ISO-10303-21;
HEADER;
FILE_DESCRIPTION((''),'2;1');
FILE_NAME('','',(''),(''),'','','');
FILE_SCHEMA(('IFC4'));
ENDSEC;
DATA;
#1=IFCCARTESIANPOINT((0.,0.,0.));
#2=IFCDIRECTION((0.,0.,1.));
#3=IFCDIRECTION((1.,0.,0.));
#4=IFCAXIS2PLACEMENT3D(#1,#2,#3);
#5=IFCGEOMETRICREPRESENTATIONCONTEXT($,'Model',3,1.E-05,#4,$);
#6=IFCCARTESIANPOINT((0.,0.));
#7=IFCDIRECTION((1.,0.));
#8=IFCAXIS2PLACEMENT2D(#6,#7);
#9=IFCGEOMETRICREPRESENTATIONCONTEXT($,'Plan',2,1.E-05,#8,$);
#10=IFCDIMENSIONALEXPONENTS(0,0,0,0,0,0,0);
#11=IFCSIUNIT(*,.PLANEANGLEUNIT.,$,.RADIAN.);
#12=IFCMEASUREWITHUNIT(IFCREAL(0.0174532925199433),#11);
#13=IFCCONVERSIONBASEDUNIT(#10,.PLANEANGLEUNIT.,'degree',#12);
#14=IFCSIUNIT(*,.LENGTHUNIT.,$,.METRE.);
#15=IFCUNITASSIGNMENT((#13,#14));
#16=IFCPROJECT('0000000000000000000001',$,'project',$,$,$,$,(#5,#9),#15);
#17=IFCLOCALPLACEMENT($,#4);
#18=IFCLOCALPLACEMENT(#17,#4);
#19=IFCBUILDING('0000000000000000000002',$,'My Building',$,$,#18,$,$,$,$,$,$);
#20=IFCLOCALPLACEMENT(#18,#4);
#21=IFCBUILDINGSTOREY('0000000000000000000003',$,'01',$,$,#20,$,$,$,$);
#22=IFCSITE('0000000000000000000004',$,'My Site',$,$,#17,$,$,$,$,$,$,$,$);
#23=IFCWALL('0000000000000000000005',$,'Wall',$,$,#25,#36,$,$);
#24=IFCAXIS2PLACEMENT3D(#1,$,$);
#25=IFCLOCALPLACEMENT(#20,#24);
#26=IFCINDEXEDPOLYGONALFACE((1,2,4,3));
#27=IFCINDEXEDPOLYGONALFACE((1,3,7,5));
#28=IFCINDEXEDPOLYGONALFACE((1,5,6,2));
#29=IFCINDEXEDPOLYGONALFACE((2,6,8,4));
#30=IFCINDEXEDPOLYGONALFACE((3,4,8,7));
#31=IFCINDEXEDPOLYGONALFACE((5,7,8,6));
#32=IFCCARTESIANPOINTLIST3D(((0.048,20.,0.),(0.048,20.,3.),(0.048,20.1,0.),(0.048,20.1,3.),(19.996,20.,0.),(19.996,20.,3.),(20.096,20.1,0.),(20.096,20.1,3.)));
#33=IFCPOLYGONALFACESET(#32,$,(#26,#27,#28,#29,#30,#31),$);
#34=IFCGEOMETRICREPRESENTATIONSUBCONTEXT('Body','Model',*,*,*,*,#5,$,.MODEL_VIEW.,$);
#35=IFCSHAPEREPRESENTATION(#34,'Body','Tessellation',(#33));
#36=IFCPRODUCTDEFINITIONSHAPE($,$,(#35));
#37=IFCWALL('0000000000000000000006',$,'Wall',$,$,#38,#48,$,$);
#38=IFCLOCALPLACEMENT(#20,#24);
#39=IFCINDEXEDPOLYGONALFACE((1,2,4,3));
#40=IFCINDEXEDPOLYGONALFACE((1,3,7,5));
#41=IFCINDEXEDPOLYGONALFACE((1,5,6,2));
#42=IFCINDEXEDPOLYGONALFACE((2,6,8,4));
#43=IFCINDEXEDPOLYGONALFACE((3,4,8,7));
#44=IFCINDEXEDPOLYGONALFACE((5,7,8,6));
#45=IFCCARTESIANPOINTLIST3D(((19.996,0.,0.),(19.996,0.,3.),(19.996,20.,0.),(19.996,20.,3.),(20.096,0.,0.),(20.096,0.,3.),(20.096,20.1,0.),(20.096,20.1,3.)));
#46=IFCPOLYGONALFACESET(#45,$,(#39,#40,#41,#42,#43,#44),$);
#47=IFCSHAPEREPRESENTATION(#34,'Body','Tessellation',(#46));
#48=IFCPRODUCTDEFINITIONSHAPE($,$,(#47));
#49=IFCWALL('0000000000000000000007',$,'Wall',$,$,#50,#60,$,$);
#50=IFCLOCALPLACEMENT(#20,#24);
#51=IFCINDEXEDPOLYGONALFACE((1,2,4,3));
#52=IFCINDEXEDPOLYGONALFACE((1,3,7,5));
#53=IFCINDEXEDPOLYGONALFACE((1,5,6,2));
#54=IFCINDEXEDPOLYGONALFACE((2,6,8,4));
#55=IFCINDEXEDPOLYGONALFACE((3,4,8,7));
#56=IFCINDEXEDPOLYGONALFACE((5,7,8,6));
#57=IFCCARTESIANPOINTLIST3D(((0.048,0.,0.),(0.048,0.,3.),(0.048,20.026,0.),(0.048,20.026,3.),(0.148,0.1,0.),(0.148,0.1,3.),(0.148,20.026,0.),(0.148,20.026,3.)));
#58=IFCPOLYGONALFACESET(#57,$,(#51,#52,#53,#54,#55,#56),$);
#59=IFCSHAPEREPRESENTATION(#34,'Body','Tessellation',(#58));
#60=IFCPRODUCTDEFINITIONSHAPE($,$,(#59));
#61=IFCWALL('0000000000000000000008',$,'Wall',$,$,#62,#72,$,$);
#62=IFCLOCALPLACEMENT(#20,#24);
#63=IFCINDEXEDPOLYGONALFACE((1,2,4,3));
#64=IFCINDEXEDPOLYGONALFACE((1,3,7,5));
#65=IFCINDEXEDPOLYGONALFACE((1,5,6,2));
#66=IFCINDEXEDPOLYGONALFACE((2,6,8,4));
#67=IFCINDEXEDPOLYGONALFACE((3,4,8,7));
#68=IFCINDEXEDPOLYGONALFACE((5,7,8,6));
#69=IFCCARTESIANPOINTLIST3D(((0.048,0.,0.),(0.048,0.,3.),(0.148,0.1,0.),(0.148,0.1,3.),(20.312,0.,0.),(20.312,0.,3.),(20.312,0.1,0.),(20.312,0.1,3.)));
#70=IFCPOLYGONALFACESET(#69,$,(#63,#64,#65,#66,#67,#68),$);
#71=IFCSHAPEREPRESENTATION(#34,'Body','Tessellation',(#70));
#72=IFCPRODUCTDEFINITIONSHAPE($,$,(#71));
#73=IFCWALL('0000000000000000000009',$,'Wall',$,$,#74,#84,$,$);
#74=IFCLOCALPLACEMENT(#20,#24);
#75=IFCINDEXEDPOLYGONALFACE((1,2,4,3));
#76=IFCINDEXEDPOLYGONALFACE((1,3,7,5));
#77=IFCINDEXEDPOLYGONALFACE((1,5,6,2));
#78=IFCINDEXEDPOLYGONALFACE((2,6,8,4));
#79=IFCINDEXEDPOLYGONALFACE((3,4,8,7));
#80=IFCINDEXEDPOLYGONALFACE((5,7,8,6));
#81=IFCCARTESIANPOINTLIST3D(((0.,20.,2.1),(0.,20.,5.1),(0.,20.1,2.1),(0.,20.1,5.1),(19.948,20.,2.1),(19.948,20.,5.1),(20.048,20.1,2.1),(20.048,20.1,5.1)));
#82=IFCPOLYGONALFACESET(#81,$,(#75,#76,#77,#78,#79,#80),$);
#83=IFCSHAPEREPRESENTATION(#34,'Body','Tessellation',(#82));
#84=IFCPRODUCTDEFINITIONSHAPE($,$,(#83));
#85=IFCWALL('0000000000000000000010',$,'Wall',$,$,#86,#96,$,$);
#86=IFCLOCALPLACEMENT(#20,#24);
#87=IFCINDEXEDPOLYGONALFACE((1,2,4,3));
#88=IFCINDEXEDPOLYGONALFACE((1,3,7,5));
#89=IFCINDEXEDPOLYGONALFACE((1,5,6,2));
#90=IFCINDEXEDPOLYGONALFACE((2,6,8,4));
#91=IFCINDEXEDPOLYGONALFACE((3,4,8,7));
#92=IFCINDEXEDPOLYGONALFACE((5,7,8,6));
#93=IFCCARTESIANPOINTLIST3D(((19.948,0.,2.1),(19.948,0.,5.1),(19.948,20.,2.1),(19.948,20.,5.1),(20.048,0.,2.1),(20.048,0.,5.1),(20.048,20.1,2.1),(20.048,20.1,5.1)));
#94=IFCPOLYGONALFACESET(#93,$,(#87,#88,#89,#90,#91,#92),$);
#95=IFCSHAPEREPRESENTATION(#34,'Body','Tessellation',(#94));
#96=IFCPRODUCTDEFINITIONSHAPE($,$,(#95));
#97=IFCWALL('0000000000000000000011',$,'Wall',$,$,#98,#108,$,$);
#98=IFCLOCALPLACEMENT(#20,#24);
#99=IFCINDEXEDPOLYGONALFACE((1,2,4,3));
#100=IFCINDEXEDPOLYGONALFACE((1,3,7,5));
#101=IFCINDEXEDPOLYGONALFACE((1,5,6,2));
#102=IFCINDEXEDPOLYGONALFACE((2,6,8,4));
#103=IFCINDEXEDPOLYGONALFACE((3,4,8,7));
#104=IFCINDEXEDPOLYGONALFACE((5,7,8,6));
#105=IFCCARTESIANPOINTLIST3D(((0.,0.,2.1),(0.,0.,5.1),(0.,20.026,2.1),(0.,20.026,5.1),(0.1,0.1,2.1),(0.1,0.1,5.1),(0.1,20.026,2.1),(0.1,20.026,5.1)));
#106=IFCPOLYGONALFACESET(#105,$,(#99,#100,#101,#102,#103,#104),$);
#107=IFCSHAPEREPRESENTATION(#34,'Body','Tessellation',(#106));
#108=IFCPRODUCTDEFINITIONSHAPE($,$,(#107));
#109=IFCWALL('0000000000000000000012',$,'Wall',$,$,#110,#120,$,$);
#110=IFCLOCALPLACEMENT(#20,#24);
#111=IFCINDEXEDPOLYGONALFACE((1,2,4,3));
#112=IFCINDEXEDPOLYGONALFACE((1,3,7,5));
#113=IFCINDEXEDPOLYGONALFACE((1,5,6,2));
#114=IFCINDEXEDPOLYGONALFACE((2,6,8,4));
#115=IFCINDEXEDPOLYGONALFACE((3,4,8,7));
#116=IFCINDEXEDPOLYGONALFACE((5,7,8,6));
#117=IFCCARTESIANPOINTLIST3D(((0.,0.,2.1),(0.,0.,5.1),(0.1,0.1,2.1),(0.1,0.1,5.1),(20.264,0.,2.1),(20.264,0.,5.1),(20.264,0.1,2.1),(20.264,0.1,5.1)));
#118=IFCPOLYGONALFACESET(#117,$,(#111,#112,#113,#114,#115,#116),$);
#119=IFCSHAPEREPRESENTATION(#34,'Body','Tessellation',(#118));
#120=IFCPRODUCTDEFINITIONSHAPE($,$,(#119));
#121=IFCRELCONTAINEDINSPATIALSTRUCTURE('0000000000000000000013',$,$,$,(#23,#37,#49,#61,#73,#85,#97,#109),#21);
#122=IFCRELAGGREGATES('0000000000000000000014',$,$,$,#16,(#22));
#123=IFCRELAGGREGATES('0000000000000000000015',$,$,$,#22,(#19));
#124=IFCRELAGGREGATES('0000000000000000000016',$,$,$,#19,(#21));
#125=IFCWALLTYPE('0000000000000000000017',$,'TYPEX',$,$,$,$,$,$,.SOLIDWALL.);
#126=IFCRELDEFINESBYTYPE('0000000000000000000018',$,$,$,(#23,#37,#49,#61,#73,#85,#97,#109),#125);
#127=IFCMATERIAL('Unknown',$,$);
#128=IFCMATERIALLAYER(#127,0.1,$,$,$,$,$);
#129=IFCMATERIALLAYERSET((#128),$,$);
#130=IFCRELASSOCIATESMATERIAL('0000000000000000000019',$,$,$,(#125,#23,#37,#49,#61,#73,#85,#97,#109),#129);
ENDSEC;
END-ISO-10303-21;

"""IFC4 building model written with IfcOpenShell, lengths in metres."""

from ifc_helpers import new_model, entity, si_unit, converted_unit, frame, origin_with_axes, origin_2d_with_axis, place, context, subcontext, project, spatial, indexed_curve, outline, extrude, clip, halfspace, material, layer, layer_set, layer_usage, type_object, element, save


model = new_model("IFC4")

# Units and contexts
model_context = context("Model", 3, precision=1e-05, world=origin_with_axes())
plan_context = context("Plan", 2, precision=1e-05, world=origin_2d_with_axis())
body_context = subcontext(model_context, "Body", "Model", "MODEL_VIEW")
ifc_project = project(units=[converted_unit("PLANEANGLEUNIT", "degree", entity("IfcReal", 0.0174532925199433), si_unit("PLANEANGLEUNIT", "RADIAN"), dimensions=[0, 0, 0, 0, 0, 0, 0]), si_unit("LENGTHUNIT", "METRE")], contexts=[model_context, plan_context])

# Site, building, storey
site_placement = place(None, origin_with_axes())
site = spatial("IfcSite", under=ifc_project, at=site_placement, Name="My Site")
building_placement = place(site_placement, origin_with_axes())
building = spatial("IfcBuilding", under=site, at=building_placement, Name="My Building")
storey_placement = place(building_placement, origin_with_axes())
storey = spatial("IfcBuildingStorey", under=building, at=storey_placement, Name="01")

# Shared definitions
ifc_material = material(Name="Unknown")

# Walls
ifc_layer_1 = layer(ifc_material, 0.1)
ifc_layer_set_1 = layer_set([ifc_layer_1])
ifc_layer_usage_1 = layer_usage(ifc_layer_set_1, "AXIS2", "POSITIVE", 0.0)
wall_type = type_object("IfcWallType", Name="TYPEX", PredefinedType="SOLIDWALL", material=ifc_layer_set_1)
wall_1_placement = place(storey_placement, frame((0.048, 20.0, 0.0), z_axis=(0.0, 0.0, 1.0), x_axis=(1.0, 0.0, 0.0)))
element("IfcWall", 1, at=wall_1_placement, inside=storey, type_object=wall_type, material=ifc_layer_usage_1, Name="Wall", context=body_context, shape_type="Clipping", body=[
    clip(extrude(outline(indexed_curve([(0.0, 0.0), (0.0, 0.1), (20.048, 0.1), (20.048, 0.0), (0.0, 0.0)], self_intersect=False)), origin_with_axes(), (0.0, 0.0, 1.0), 3.0), halfspace(frame((19.948, 0.0, 0.0), z_axis=(0.707107, -0.707107, 0.0), x_axis=(-0.707107, -0.707107, 0.0)), False)),
])
ifc_layer_usage_2 = layer_usage(ifc_layer_set_1, "AXIS2", "POSITIVE", 0.0)
wall_2_placement = place(storey_placement, frame((19.996, 20.1, 0.0), z_axis=(0.0, 0.0, 1.0), x_axis=(0.0, -1.0, 0.0)))
element("IfcWall", 2, at=wall_2_placement, inside=storey, type_object=wall_type, material=ifc_layer_usage_2, Name="Wall", context=body_context, shape_type="Clipping", body=[
    clip(extrude(outline(indexed_curve([(0.0, 0.0), (0.0, 0.1), (20.1, 0.1), (20.1, 0.0), (0.0, 0.0)], self_intersect=False)), origin_with_axes(), (0.0, 0.0, 1.0), 3.0), halfspace(frame((0.1, 0.0, 0.0), z_axis=(-0.707107, -0.707107, 0.0), x_axis=(-0.707107, 0.707107, 0.0)), False)),
])
ifc_layer_usage_3 = layer_usage(ifc_layer_set_1, "AXIS2", "POSITIVE", 0.0)
wall_3_placement = place(storey_placement, frame((0.048, 20.026, 0.0), z_axis=(0.0, 0.0, 1.0), x_axis=(0.0, -1.0, 0.0)))
element("IfcWall", 3, at=wall_3_placement, inside=storey, type_object=wall_type, material=ifc_layer_usage_3, Name="Wall", context=body_context, shape_type="Clipping", body=[
    clip(extrude(outline(indexed_curve([(0.0, 0.0), (0.0, 0.1), (20.026, 0.1), (20.026, 0.0), (0.0, 0.0)], self_intersect=False)), origin_with_axes(), (0.0, 0.0, 1.0), 3.0), halfspace(frame((20.026, 0.0, 0.0), z_axis=(0.707107, 0.707107, 0.0), x_axis=(0.707107, -0.707107, 0.0)), False)),
])
ifc_layer_usage_4 = layer_usage(ifc_layer_set_1, "AXIS2", "POSITIVE", 0.0)
wall_4_placement = place(storey_placement, frame((0.048, 0.0, 0.0), z_axis=(0.0, 0.0, 1.0), x_axis=(1.0, 0.0, 0.0)))
element("IfcWall", 4, at=wall_4_placement, inside=storey, type_object=wall_type, material=ifc_layer_usage_4, Name="Wall", context=body_context, shape_type="Clipping", body=[
    clip(extrude(outline(indexed_curve([(0.0, 0.0), (0.0, 0.1), (20.264, 0.1), (20.264, 0.0), (0.0, 0.0)], self_intersect=False)), origin_with_axes(), (0.0, 0.0, 1.0), 3.0), halfspace(frame((0.0, 0.0, 0.0), z_axis=(-0.707107, 0.707107, 0.0), x_axis=(0.707107, 0.707107, 0.0)), False)),
])
ifc_layer_usage_5 = layer_usage(ifc_layer_set_1, "AXIS2", "POSITIVE", 0.0)
wall_5_placement = place(storey_placement, frame((0.0, 20.0, 2.1), z_axis=(0.0, 0.0, 1.0), x_axis=(1.0, 0.0, 0.0)))
element("IfcWall", 5, at=wall_5_placement, inside=storey, type_object=wall_type, material=ifc_layer_usage_5, Name="Wall", context=body_context, shape_type="Clipping", body=[
    clip(extrude(outline(indexed_curve([(0.0, 0.0), (0.0, 0.1), (20.048, 0.1), (20.048, 0.0), (0.0, 0.0)], self_intersect=False)), origin_with_axes(), (0.0, 0.0, 1.0), 3.0), halfspace(frame((19.948, 0.0, 0.0), z_axis=(0.707107, -0.707107, 0.0), x_axis=(-0.707107, -0.707107, 0.0)), False)),
])
ifc_layer_usage_6 = layer_usage(ifc_layer_set_1, "AXIS2", "POSITIVE", 0.0)
wall_6_placement = place(storey_placement, frame((19.948, 20.1, 2.1), z_axis=(0.0, 0.0, 1.0), x_axis=(0.0, -1.0, 0.0)))
element("IfcWall", 6, at=wall_6_placement, inside=storey, type_object=wall_type, material=ifc_layer_usage_6, Name="Wall", context=body_context, shape_type="Clipping", body=[
    clip(extrude(outline(indexed_curve([(0.0, 0.0), (0.0, 0.1), (20.1, 0.1), (20.1, 0.0), (0.0, 0.0)], self_intersect=False)), origin_with_axes(), (0.0, 0.0, 1.0), 3.0), halfspace(frame((0.1, 0.0, 0.0), z_axis=(-0.707107, -0.707107, 0.0), x_axis=(-0.707107, 0.707107, 0.0)), False)),
])
ifc_layer_usage_7 = layer_usage(ifc_layer_set_1, "AXIS2", "POSITIVE", 0.0)
wall_7_placement = place(storey_placement, frame((0.0, 20.026, 2.1), z_axis=(0.0, 0.0, 1.0), x_axis=(0.0, -1.0, 0.0)))
element("IfcWall", 7, at=wall_7_placement, inside=storey, type_object=wall_type, material=ifc_layer_usage_7, Name="Wall", context=body_context, shape_type="Clipping", body=[
    clip(extrude(outline(indexed_curve([(0.0, 0.0), (0.0, 0.1), (20.026, 0.1), (20.026, 0.0), (0.0, 0.0)], self_intersect=False)), origin_with_axes(), (0.0, 0.0, 1.0), 3.0), halfspace(frame((20.026, 0.0, 0.0), z_axis=(0.707107, 0.707107, 0.0), x_axis=(0.707107, -0.707107, 0.0)), False)),
])
ifc_layer_usage_8 = layer_usage(ifc_layer_set_1, "AXIS2", "POSITIVE", 0.0)
wall_8_placement = place(storey_placement, frame((0.0, 0.0, 2.1), z_axis=(0.0, 0.0, 1.0), x_axis=(1.0, 0.0, 0.0)))
element("IfcWall", 8, at=wall_8_placement, inside=storey, type_object=wall_type, material=ifc_layer_usage_8, Name="Wall", context=body_context, shape_type="Clipping", body=[
    clip(extrude(outline(indexed_curve([(0.0, 0.0), (0.0, 0.1), (20.264, 0.1), (20.264, 0.0), (0.0, 0.0)], self_intersect=False)), origin_with_axes(), (0.0, 0.0, 1.0), 3.0), halfspace(frame((0.0, 0.0, 0.0), z_axis=(-0.707107, 0.707107, 0.0), x_axis=(0.707107, 0.707107, 0.0)), False)),
])

save(model, "model.ifc")
